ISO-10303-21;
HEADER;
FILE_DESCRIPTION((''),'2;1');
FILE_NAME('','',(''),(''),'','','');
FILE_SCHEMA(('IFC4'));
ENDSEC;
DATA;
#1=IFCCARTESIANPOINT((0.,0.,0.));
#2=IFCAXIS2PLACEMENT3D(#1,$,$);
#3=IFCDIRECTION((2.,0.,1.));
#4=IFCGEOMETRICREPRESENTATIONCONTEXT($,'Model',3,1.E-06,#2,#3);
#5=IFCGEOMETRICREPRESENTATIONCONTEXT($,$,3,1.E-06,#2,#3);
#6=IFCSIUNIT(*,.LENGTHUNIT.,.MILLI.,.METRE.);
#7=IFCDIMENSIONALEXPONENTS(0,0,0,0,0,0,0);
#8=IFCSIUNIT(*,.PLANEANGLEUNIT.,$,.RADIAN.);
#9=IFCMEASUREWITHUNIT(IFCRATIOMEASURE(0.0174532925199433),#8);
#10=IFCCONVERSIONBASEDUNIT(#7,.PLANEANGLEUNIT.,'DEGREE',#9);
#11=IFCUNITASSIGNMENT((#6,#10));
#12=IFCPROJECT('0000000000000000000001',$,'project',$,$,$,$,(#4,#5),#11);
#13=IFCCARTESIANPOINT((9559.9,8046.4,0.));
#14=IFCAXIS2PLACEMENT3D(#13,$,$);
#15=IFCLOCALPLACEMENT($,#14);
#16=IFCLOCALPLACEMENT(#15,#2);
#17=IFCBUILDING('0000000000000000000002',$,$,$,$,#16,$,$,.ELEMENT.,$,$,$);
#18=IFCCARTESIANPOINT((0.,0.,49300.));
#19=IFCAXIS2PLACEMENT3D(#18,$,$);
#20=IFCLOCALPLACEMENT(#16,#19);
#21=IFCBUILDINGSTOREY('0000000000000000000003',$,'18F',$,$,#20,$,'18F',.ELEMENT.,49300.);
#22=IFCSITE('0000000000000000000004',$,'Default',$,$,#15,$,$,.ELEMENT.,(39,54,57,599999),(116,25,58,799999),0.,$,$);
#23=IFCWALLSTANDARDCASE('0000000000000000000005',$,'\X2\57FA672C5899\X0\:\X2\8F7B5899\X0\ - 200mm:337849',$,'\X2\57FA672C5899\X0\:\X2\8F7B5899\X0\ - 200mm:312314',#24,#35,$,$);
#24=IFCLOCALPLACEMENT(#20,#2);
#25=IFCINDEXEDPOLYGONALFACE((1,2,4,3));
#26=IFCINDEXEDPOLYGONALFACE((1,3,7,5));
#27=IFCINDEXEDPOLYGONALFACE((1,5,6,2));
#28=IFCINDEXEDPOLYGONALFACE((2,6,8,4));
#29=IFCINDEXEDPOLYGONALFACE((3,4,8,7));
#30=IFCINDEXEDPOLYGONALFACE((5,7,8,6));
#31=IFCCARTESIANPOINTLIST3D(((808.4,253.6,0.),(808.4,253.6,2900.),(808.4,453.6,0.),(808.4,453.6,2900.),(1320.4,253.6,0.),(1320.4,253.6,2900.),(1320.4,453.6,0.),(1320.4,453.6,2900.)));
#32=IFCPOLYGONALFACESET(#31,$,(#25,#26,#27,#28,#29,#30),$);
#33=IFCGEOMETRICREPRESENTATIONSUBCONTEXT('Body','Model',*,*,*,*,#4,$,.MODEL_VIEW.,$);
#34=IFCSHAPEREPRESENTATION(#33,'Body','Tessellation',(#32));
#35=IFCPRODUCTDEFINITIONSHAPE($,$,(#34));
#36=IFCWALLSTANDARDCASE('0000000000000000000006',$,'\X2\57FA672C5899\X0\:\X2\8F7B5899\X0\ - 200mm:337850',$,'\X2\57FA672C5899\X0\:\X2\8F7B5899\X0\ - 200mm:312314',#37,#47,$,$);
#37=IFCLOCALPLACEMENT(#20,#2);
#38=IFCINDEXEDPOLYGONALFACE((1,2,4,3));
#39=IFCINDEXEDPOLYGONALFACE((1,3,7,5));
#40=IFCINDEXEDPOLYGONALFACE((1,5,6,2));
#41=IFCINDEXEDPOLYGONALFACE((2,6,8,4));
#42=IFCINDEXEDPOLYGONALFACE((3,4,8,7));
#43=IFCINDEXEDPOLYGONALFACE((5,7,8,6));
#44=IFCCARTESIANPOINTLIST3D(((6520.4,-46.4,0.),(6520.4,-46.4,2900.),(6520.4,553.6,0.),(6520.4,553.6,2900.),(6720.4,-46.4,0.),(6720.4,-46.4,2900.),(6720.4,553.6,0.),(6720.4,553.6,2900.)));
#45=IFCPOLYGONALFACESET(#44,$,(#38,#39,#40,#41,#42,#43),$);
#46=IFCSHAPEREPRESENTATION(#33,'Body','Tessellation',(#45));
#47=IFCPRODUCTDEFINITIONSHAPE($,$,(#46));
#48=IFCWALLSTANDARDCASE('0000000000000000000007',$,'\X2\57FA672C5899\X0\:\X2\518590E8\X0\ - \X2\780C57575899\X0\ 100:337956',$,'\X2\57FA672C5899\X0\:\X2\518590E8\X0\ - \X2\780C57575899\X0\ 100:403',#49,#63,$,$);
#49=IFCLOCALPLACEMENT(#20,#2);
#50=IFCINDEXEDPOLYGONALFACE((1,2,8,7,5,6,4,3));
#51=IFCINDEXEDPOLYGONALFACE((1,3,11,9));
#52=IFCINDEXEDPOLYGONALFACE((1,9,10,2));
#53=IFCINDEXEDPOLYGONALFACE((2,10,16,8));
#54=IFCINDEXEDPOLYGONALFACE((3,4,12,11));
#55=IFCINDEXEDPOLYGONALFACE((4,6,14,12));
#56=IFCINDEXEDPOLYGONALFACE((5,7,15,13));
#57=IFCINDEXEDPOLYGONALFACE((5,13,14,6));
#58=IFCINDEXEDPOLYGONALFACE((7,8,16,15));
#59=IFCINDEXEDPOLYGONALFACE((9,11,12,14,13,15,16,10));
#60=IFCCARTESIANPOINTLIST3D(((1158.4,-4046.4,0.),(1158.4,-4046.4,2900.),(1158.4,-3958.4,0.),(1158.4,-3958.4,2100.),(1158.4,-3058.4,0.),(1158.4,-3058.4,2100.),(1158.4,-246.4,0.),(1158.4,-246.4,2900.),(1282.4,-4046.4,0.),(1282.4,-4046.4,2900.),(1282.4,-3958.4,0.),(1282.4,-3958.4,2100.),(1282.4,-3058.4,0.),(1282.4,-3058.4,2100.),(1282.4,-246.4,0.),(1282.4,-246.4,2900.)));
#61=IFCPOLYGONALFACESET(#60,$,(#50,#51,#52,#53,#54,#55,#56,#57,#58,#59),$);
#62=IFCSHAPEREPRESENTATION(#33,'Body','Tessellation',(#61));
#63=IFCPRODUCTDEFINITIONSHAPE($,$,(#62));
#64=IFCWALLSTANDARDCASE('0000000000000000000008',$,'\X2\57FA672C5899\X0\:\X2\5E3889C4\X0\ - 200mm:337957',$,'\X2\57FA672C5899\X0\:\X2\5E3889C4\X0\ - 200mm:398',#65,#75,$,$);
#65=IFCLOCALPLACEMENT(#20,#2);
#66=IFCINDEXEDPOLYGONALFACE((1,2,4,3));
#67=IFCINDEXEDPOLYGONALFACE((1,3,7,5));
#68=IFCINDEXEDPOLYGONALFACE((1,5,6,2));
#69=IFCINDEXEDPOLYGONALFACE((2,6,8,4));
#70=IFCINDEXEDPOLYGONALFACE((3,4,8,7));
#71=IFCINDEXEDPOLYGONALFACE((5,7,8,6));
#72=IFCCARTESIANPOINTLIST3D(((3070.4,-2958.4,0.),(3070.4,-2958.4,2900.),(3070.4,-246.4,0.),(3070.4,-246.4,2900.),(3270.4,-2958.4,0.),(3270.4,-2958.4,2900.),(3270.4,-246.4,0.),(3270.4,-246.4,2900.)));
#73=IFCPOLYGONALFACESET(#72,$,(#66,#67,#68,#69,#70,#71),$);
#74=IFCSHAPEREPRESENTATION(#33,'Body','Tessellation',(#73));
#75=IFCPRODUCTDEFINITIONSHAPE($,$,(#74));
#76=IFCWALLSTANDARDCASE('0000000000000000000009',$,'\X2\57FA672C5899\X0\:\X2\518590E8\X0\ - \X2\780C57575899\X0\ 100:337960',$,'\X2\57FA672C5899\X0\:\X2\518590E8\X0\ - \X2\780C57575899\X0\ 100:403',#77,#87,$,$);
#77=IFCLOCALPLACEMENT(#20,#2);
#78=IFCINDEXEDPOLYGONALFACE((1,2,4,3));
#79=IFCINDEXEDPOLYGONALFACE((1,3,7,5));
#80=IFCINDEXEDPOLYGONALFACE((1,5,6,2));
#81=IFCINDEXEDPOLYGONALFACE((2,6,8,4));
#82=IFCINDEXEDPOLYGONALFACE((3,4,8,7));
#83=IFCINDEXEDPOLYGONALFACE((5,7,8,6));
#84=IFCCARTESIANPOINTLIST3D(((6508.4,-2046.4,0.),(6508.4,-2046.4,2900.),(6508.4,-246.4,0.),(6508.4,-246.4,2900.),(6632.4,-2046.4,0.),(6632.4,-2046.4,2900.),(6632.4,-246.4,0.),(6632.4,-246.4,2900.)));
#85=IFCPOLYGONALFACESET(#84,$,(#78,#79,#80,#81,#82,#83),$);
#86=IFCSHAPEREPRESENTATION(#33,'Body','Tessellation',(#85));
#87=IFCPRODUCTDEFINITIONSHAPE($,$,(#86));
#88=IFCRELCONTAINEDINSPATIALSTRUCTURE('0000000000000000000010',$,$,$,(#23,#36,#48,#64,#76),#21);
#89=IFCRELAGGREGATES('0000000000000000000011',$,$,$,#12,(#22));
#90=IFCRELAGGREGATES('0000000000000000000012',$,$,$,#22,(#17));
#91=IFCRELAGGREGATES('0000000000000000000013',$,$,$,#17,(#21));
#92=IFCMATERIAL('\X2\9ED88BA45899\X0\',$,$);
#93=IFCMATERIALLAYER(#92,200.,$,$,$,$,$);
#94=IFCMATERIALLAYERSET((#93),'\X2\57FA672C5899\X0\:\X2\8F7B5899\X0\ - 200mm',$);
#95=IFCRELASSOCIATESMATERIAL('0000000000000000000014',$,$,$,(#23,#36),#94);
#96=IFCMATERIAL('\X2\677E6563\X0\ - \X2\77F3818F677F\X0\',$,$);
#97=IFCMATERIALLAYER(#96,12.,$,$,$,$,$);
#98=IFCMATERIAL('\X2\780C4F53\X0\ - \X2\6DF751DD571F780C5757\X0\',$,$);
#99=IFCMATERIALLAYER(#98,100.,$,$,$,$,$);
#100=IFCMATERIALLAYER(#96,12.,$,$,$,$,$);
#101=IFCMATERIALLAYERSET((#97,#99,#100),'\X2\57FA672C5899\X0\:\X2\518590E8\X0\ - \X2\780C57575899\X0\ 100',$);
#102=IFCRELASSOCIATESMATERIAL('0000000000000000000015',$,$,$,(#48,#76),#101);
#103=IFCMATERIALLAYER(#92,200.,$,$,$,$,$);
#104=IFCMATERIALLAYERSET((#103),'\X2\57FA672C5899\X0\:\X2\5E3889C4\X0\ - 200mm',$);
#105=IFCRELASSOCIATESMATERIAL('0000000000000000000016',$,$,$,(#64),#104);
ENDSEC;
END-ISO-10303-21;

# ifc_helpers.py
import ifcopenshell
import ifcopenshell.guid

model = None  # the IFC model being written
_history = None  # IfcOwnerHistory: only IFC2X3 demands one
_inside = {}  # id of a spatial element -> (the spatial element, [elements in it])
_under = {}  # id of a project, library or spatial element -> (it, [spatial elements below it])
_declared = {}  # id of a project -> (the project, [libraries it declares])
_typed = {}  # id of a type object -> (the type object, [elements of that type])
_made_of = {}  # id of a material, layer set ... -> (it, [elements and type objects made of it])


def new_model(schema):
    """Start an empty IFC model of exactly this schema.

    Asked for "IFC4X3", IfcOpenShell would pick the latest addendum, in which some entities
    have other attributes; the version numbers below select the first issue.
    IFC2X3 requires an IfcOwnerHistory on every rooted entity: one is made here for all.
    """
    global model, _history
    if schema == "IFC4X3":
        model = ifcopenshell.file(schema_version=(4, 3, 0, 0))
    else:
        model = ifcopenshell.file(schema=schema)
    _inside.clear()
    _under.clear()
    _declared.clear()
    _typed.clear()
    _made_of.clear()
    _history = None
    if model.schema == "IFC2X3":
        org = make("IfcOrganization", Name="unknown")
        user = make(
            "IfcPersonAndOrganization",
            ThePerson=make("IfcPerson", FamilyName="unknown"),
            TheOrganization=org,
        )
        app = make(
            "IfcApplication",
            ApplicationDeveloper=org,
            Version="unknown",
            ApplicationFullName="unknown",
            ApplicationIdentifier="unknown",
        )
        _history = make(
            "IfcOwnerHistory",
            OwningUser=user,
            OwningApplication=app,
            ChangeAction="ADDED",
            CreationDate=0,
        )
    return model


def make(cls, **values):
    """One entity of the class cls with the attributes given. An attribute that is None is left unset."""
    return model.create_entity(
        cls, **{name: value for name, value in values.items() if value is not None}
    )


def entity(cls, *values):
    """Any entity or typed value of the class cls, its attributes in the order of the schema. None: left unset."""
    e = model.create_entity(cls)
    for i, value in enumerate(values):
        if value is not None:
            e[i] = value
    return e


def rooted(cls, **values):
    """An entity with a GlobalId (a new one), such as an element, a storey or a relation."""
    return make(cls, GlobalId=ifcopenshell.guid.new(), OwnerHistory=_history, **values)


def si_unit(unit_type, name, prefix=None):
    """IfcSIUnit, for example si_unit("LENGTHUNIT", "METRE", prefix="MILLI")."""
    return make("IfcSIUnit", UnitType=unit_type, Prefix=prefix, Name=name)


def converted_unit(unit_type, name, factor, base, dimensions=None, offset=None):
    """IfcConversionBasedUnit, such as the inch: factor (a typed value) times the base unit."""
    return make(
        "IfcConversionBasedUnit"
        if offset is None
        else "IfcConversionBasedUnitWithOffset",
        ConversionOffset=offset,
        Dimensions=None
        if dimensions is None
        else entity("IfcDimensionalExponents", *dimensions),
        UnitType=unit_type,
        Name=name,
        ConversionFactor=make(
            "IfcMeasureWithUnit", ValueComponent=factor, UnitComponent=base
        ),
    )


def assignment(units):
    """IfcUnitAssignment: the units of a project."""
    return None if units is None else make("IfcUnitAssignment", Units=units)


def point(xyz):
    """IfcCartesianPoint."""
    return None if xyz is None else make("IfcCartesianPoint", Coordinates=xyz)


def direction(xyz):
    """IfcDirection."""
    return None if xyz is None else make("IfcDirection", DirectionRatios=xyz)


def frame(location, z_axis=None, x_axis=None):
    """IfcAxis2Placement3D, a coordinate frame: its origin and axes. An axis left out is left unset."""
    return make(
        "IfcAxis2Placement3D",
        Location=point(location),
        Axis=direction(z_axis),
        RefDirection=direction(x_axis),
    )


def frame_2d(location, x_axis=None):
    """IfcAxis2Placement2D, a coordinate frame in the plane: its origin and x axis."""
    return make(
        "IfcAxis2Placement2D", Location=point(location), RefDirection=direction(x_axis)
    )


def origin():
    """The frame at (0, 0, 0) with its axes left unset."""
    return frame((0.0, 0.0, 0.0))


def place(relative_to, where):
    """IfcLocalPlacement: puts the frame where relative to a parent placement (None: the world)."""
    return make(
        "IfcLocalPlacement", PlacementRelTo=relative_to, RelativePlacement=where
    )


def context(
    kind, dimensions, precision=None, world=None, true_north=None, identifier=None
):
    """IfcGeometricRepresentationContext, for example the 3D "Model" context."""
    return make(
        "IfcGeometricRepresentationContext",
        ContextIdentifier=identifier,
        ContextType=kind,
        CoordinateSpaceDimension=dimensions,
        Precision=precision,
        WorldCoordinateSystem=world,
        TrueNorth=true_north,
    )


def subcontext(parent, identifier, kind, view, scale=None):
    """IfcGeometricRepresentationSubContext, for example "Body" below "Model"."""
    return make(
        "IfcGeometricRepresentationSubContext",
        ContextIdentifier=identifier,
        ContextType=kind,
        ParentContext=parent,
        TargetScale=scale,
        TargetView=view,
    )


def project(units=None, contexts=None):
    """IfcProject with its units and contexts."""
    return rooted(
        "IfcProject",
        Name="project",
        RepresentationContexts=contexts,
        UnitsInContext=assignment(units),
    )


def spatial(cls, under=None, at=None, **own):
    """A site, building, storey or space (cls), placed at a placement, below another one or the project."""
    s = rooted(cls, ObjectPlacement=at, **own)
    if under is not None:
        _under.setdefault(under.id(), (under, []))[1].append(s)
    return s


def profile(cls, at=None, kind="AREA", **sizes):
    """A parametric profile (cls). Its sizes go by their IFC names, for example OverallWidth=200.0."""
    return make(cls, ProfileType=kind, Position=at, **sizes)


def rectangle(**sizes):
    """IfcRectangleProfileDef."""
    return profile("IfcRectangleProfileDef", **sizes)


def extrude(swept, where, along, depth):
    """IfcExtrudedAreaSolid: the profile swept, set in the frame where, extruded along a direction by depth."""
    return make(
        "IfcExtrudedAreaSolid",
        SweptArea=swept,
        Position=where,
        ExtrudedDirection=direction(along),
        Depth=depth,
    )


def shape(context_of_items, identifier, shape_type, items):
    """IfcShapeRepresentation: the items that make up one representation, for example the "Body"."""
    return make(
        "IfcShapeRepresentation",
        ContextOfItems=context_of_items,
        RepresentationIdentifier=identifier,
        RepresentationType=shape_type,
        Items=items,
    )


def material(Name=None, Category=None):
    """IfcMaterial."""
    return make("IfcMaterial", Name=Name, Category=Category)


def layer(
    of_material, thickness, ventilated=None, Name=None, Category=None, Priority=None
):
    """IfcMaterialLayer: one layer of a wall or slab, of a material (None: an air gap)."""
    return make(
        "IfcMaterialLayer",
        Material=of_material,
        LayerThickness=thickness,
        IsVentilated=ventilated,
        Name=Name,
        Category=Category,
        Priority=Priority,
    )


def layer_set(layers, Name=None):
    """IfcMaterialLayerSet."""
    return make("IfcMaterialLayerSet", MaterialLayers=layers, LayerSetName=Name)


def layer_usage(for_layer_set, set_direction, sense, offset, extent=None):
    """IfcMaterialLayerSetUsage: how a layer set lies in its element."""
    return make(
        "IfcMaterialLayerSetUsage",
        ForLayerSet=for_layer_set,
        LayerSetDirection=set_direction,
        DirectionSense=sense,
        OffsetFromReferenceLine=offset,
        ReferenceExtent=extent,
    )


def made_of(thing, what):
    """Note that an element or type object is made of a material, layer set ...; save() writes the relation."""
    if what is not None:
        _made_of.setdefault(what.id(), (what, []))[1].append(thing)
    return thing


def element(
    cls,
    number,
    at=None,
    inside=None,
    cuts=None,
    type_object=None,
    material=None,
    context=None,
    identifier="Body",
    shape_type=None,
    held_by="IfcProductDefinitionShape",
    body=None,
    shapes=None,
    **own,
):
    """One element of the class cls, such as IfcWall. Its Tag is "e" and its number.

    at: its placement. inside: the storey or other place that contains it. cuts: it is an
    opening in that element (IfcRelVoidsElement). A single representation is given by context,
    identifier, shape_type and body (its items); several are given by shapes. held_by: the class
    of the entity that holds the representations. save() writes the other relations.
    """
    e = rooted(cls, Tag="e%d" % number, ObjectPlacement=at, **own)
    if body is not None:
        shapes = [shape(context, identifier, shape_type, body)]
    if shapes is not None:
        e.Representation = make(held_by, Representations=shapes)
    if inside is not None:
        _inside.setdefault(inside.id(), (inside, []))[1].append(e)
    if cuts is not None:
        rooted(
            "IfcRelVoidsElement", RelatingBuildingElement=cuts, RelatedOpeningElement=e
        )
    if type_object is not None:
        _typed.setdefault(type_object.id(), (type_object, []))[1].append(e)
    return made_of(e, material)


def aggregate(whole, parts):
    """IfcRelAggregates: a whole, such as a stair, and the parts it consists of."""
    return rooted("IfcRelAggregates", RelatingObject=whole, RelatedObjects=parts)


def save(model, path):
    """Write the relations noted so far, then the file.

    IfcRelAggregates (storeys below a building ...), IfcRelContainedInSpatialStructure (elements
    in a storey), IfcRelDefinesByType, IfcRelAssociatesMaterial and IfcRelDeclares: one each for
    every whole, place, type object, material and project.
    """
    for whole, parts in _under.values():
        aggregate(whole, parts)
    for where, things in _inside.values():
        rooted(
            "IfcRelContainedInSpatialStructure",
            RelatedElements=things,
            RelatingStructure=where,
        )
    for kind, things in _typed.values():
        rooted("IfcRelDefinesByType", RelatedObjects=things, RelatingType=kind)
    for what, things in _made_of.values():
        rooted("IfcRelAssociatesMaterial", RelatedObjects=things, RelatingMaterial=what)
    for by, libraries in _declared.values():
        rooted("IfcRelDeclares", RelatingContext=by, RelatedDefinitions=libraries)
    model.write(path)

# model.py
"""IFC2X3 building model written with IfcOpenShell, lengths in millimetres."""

from ifc_helpers import new_model, entity, si_unit, converted_unit, direction, frame, frame_2d, origin, place, context, subcontext, project, spatial, rectangle, extrude, material, layer, layer_set, layer_usage, element, save


model = new_model("IFC2X3")

# Units and contexts
model_context = context("Model", 3, precision=1e-06, world=origin(), true_north=direction((2.0, 0.0, 1.0)))
context_of_model = context(None, 3, precision=1e-06, world=origin(), true_north=direction((2.0, 0.0, 1.0)))
body_context = subcontext(model_context, "Body", "Model", "MODEL_VIEW")
ifc_project = project(units=[si_unit("LENGTHUNIT", "METRE", prefix="MILLI"), converted_unit("PLANEANGLEUNIT", "DEGREE", entity("IfcRatioMeasure", 0.0174532925199433), si_unit("PLANEANGLEUNIT", "RADIAN"), dimensions=[0, 0, 0, 0, 0, 0, 0])], contexts=[model_context, context_of_model])

# Site, building, storey
site_placement = place(None, frame((9559.9, 8046.4, 0.0)))
site = spatial("IfcSite", under=ifc_project, at=site_placement, Name="Default", CompositionType="ELEMENT", RefLatitude=(39, 54, 57, 599999), RefLongitude=(116, 25, 58, 799999), RefElevation=0.0)
building_placement = place(site_placement, origin())
building = spatial("IfcBuilding", under=site, at=building_placement, CompositionType="ELEMENT")
storey_placement = place(building_placement, frame((0.0, 0.0, 49300.0)))
storey = spatial("IfcBuildingStorey", under=building, at=storey_placement, Name="18F", LongName="18F", CompositionType="ELEMENT", Elevation=49300.0)

# Shared definitions
ifc_material_1 = material(Name="默认墙")

# Shared definitions
ifc_layer_1 = layer(ifc_material_1, 200.0)
ifc_layer_set_1 = layer_set([ifc_layer_1], Name="基本墙:轻墙 - 200mm")
ifc_material_2 = material(Name="松散 - 石膏板")
ifc_layer_2 = layer(ifc_material_2, 12.0)
ifc_material_3 = material(Name="砌体 - 混凝土砌块")
ifc_layer_3 = layer(ifc_material_3, 100.0)
ifc_layer_4 = layer(ifc_material_2, 12.0)
ifc_layer_set_2 = layer_set([ifc_layer_2, ifc_layer_3, ifc_layer_4], Name="基本墙:内部 - 砌块墙 100")

# Walls
ifc_layer_usage_1 = layer_usage(ifc_layer_set_1, "AXIS2", "NEGATIVE", 100.0)
wall_1_placement = place(storey_placement, frame((808.4, 353.6, 0.0)))
element("IfcWallStandardCase", 1, at=wall_1_placement, inside=storey, material=ifc_layer_usage_1, Name="基本墙:轻墙 - 200mm:337849", ObjectType="基本墙:轻墙 - 200mm:312314", context=body_context, shape_type="SweptSolid", body=[
    extrude(rectangle(XDim=512.0, YDim=200.0, at=frame_2d((256.0, 0.0), x_axis=(-1.0, 0.0))), origin(), (0.0, 0.0, 1.0), 2900.0),
])
ifc_layer_usage_2 = layer_usage(ifc_layer_set_1, "AXIS2", "NEGATIVE", 100.0)
wall_2_placement = place(storey_placement, frame((6620.4, -46.4, 0.0), z_axis=(0.0, 0.0, 1.0), x_axis=(0.0, 1.0, 0.0)))
element("IfcWallStandardCase", 2, at=wall_2_placement, inside=storey, material=ifc_layer_usage_2, Name="基本墙:轻墙 - 200mm:337850", ObjectType="基本墙:轻墙 - 200mm:312314", context=body_context, shape_type="SweptSolid", body=[
    extrude(rectangle(XDim=600.0, YDim=200.0, at=frame_2d((300.0, 0.0), x_axis=(-1.0, 0.0))), origin(), (0.0, 0.0, 1.0), 2900.0),
])

# Wall, opening
ifc_layer_usage_3 = layer_usage(ifc_layer_set_2, "AXIS2", "NEGATIVE", 62.0)
wall_3_placement = place(storey_placement, frame((1220.4, -246.4, 0.0), z_axis=(0.0, 0.0, 1.0), x_axis=(0.0, -1.0, 0.0)))
wall_3 = element("IfcWallStandardCase", 3, at=wall_3_placement, inside=storey, material=ifc_layer_usage_3, Name="基本墙:内部 - 砌块墙 100:337956", ObjectType="基本墙:内部 - 砌块墙 100:403", context=body_context, shape_type="SweptSolid", body=[
    extrude(rectangle(XDim=3800.0, YDim=124.0, at=frame_2d((1900.0, 0.0), x_axis=(-1.0, 0.0))), origin(), (0.0, 0.0, 1.0), 2900.0),
])
opening_1_placement = place(wall_3_placement, frame((3712.0, 62.0, 0.0)))
element("IfcOpeningElement", 4, at=opening_1_placement, cuts=wall_3, ObjectType="Opening", context=body_context, shape_type="SweptSolid", body=[
    extrude(rectangle(XDim=2100.0, YDim=900.0, at=frame_2d((1050.0, 450.0), x_axis=(1.0, 0.0))), frame((0.0, 0.0, 0.0), z_axis=(0.0, -1.0, 0.0), x_axis=(0.0, 0.0, 1.0)), (0.0, 0.0, 1.0), 124.0),
])

# Walls
ifc_layer_5 = layer(ifc_material_1, 200.0)
ifc_layer_set_3 = layer_set([ifc_layer_5], Name="基本墙:常规 - 200mm")
ifc_layer_usage_4 = layer_usage(ifc_layer_set_3, "AXIS2", "NEGATIVE", 100.0)
wall_4_placement = place(storey_placement, frame((3170.4, -246.4, 0.0), z_axis=(0.0, 0.0, 1.0), x_axis=(0.0, -1.0, 0.0)))
element("IfcWallStandardCase", 5, at=wall_4_placement, inside=storey, material=ifc_layer_usage_4, Name="基本墙:常规 - 200mm:337957", ObjectType="基本墙:常规 - 200mm:398", context=body_context, shape_type="SweptSolid", body=[
    extrude(rectangle(XDim=2712.0, YDim=200.0, at=frame_2d((1356.0, 0.0), x_axis=(-1.0, 0.0))), origin(), (0.0, 0.0, 1.0), 2900.0),
])
ifc_layer_usage_5 = layer_usage(ifc_layer_set_2, "AXIS2", "NEGATIVE", 62.0)
wall_5_placement = place(storey_placement, frame((6570.4, -246.4, 0.0), z_axis=(0.0, 0.0, 1.0), x_axis=(0.0, -1.0, 0.0)))
element("IfcWallStandardCase", 6, at=wall_5_placement, inside=storey, material=ifc_layer_usage_5, Name="基本墙:内部 - 砌块墙 100:337960", ObjectType="基本墙:内部 - 砌块墙 100:403", context=body_context, shape_type="SweptSolid", body=[
    extrude(rectangle(XDim=1800.0, YDim=124.0, at=frame_2d((900.0, 0.0), x_axis=(-1.0, 0.0))), origin(), (0.0, 0.0, 1.0), 2900.0),
])

save(model, "model.ifc")
